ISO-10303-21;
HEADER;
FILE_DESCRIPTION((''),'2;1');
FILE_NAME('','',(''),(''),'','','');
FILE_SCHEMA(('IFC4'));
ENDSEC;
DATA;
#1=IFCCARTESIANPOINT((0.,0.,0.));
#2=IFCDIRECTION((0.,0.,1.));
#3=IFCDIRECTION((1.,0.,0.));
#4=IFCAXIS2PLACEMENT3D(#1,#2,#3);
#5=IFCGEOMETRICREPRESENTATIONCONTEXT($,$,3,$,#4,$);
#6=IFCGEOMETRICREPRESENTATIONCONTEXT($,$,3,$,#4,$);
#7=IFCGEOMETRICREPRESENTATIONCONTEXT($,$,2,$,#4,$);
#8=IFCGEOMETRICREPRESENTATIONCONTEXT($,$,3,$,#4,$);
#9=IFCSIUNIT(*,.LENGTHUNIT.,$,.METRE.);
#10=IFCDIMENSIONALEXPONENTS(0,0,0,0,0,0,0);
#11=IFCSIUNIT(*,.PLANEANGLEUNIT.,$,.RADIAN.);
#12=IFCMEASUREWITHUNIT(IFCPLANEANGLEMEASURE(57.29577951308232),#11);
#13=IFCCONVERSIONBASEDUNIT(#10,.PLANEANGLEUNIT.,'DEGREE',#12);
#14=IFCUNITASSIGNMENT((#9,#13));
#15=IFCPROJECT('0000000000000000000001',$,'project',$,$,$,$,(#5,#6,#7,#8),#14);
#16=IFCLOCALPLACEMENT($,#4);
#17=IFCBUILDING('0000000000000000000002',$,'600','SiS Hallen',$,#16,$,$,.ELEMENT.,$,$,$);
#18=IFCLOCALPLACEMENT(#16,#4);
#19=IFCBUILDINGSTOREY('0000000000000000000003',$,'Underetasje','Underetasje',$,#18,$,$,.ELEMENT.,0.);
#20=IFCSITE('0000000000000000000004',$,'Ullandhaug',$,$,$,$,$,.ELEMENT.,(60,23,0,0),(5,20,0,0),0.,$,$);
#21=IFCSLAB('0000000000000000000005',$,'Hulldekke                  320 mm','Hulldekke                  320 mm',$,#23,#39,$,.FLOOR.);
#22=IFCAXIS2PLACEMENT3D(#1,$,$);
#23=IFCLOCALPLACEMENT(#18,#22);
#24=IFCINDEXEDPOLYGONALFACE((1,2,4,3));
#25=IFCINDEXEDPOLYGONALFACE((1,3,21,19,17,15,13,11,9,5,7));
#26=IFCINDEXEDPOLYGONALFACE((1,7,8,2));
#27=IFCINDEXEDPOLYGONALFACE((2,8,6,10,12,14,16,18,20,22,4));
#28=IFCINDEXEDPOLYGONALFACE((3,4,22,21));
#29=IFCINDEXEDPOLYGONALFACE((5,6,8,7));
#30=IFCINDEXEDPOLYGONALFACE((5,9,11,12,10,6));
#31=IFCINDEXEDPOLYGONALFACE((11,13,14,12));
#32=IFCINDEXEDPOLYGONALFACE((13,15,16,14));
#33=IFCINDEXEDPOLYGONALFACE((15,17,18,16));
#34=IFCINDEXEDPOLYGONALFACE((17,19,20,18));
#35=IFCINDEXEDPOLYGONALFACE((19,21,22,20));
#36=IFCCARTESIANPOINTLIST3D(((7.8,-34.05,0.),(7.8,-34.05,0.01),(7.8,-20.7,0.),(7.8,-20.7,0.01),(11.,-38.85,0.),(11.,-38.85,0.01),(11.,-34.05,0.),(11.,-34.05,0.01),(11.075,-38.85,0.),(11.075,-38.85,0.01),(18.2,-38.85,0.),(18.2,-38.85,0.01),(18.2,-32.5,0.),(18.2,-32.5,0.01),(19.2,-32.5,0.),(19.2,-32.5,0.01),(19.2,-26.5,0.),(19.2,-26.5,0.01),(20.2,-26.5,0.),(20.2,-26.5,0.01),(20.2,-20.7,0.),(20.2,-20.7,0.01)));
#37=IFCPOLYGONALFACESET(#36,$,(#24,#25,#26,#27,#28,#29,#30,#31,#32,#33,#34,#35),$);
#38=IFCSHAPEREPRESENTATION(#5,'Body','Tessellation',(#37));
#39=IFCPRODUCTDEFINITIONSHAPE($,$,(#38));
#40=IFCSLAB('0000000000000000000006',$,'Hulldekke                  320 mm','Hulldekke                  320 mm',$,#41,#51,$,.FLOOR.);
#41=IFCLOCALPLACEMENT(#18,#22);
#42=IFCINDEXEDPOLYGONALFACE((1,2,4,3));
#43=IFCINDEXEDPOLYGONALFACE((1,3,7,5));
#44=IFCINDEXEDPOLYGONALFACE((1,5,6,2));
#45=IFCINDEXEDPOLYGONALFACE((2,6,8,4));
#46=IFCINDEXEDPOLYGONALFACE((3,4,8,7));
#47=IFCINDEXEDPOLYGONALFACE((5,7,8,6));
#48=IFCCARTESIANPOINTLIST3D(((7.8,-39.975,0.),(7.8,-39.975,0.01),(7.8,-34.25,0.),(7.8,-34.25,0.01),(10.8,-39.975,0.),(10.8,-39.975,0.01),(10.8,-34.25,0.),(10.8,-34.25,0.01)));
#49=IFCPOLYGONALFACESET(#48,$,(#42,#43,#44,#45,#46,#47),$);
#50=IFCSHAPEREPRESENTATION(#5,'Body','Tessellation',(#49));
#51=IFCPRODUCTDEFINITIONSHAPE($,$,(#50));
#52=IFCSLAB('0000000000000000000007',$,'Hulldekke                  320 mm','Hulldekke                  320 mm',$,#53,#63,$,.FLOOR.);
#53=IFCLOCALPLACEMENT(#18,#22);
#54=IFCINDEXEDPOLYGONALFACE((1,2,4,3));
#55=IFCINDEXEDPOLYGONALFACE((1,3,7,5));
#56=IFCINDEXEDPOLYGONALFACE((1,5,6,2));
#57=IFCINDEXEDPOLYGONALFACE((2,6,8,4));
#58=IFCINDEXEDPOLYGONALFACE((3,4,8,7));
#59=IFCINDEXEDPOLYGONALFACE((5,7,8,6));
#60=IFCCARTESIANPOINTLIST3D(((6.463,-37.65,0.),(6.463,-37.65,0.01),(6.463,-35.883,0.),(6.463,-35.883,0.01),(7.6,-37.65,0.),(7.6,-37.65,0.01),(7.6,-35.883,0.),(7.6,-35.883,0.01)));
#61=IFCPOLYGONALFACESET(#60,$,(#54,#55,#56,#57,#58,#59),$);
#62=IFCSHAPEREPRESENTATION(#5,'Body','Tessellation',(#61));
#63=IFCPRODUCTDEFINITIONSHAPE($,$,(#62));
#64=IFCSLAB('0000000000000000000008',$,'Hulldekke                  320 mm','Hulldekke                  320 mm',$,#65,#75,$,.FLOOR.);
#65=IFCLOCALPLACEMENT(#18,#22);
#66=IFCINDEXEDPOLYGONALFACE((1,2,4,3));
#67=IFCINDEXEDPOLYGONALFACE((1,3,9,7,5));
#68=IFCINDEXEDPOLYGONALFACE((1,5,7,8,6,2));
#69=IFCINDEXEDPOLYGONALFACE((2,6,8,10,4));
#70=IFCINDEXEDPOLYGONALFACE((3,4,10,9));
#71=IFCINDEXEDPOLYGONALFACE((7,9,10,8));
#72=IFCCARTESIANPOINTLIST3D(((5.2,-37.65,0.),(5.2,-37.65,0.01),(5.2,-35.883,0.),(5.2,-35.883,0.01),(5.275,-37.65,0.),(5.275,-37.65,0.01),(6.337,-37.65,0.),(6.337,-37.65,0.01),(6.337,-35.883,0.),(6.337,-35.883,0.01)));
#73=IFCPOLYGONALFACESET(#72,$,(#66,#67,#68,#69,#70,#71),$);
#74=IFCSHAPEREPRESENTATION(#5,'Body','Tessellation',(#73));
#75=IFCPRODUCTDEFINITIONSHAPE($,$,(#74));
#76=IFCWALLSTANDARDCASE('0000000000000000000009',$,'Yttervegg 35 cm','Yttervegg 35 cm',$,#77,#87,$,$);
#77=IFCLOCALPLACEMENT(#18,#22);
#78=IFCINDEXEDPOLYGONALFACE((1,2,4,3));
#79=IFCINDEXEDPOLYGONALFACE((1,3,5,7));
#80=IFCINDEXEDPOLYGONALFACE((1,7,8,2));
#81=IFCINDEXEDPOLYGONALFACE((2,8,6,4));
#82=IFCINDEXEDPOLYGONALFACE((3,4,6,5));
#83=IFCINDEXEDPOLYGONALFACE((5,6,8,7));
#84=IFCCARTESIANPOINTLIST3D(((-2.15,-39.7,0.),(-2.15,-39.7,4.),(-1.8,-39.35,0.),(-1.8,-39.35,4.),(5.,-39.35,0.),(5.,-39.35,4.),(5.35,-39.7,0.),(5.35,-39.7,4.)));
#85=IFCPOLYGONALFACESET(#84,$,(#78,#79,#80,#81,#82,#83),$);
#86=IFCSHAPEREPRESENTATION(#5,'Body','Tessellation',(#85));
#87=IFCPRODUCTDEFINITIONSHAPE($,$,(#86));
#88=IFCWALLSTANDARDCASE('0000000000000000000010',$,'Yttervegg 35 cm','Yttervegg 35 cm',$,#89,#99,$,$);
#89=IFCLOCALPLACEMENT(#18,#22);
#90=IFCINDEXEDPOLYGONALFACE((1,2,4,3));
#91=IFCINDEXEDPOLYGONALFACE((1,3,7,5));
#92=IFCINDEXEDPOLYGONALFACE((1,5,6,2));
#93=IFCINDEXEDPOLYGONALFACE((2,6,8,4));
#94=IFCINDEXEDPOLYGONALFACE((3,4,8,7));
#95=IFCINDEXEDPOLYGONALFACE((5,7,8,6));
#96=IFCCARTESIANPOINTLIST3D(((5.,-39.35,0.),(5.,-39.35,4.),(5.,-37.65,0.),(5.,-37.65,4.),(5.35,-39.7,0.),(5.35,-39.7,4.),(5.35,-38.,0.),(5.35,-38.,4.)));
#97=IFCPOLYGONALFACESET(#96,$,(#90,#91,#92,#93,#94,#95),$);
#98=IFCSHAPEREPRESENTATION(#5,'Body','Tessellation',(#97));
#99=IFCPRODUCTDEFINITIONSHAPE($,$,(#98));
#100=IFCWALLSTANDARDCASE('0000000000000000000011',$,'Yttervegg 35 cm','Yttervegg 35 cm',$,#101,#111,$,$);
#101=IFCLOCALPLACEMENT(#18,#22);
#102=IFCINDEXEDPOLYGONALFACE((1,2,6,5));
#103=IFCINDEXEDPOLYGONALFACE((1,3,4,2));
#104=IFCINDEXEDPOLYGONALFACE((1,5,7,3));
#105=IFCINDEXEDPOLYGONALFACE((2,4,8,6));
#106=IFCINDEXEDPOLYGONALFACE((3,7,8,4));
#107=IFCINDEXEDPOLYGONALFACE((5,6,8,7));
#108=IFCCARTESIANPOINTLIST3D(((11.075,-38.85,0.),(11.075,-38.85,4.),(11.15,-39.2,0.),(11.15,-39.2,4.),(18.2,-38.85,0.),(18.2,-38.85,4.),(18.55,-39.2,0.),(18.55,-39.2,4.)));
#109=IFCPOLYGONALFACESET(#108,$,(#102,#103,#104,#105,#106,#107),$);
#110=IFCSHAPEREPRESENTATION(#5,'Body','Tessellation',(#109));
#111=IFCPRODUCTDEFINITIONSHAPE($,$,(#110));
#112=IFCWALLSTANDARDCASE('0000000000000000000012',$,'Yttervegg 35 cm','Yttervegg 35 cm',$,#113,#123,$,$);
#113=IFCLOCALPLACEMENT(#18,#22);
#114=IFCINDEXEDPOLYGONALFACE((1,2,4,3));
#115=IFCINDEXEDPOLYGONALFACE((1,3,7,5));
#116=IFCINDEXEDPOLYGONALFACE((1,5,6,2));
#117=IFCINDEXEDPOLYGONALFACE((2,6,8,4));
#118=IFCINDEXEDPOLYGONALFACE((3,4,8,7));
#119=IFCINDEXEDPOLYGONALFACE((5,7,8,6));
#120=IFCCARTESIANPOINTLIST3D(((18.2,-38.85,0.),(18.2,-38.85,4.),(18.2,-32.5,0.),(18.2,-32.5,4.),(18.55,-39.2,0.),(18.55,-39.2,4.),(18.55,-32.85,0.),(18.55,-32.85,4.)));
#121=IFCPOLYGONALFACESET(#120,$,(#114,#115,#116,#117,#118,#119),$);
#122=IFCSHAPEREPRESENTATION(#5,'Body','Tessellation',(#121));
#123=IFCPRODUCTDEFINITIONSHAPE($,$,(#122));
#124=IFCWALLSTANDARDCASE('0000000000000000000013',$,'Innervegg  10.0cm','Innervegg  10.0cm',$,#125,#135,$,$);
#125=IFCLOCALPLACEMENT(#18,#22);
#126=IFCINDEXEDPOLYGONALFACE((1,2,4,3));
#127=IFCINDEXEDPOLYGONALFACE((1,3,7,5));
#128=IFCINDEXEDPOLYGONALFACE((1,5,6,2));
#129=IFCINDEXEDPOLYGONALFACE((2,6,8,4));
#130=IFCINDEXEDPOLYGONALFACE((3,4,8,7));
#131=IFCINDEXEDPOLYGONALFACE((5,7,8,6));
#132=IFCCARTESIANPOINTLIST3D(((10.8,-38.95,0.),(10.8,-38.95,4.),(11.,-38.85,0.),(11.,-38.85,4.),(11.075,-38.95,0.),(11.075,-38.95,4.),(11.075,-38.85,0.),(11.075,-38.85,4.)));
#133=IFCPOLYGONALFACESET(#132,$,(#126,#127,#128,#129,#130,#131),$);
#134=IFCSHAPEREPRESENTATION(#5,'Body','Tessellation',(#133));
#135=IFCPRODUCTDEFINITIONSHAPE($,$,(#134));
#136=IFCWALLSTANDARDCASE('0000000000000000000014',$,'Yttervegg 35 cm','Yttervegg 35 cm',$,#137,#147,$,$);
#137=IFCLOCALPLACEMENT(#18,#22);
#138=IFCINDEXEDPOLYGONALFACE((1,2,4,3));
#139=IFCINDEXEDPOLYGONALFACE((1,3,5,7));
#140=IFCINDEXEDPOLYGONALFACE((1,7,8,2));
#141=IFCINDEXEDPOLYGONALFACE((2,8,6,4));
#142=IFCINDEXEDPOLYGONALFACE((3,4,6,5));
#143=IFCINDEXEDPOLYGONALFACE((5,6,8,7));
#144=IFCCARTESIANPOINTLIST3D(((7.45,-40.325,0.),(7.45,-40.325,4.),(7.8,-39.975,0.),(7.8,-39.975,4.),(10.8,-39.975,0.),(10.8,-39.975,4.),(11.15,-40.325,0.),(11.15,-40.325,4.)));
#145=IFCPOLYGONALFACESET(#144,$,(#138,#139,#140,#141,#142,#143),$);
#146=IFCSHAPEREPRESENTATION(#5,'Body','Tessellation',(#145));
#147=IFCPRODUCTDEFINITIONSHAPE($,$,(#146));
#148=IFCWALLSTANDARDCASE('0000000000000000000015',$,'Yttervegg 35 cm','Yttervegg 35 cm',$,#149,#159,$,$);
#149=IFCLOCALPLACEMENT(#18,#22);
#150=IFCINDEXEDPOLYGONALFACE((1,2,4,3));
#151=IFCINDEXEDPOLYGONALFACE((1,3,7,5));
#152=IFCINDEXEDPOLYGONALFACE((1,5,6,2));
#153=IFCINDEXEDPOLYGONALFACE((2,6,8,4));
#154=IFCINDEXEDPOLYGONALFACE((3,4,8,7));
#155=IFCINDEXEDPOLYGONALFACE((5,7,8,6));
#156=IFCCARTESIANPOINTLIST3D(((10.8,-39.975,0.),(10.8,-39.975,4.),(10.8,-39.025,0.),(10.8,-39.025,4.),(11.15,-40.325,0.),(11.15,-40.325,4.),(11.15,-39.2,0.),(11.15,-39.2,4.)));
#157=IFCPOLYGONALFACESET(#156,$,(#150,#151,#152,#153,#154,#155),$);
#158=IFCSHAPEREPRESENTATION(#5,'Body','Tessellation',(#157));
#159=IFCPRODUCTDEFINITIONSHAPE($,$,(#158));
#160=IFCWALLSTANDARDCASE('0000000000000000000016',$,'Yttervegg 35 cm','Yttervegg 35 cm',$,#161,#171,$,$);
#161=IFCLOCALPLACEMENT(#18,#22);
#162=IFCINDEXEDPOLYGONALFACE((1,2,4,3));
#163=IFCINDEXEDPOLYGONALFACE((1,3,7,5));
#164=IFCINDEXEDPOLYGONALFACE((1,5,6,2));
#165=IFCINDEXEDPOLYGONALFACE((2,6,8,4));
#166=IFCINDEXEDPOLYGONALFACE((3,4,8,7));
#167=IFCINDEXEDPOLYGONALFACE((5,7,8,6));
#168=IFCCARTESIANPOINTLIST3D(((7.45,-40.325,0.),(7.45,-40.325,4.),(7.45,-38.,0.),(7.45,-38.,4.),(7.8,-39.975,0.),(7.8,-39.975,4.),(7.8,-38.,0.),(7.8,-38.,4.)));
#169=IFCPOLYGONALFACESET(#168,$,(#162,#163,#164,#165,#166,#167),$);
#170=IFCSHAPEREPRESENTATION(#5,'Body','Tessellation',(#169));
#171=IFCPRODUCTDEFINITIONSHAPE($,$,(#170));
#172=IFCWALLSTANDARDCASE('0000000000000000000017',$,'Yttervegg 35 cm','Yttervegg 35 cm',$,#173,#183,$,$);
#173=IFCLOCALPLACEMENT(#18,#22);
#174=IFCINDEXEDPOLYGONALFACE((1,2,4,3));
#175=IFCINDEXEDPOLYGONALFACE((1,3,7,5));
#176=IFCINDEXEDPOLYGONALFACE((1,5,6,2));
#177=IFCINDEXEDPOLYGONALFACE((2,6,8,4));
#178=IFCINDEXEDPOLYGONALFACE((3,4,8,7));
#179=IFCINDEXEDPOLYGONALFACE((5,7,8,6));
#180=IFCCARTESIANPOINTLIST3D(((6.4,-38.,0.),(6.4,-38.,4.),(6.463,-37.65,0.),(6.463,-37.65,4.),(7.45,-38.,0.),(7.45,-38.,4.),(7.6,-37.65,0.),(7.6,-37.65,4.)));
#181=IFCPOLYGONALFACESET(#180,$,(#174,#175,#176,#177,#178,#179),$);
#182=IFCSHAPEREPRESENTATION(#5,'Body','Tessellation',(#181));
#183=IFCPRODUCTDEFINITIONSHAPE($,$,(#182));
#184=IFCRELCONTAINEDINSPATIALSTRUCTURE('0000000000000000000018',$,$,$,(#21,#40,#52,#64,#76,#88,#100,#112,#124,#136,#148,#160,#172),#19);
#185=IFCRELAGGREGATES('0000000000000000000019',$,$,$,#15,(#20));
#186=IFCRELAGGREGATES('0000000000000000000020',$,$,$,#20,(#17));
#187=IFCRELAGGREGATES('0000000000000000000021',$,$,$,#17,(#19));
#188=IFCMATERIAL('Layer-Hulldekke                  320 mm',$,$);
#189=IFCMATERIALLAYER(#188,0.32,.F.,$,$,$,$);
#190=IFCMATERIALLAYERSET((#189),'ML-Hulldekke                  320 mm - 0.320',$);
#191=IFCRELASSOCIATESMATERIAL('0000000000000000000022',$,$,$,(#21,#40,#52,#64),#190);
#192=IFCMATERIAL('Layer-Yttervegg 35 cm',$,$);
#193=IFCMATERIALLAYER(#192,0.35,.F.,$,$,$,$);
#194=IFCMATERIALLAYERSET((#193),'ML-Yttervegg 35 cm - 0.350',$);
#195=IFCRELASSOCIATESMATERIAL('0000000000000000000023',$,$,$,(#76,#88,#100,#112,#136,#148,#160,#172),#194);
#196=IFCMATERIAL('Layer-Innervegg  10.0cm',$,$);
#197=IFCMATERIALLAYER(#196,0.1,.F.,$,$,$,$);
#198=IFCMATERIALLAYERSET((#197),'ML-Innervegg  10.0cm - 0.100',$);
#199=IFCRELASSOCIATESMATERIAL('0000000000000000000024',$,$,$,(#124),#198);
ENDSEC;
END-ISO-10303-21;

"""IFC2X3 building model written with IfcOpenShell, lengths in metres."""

from ifc_helpers import new_model, entity, si_unit, converted_unit, frame, origin_with_axes, place, context, project, spatial, polyline, outline, extrude, material, layer, layer_set, layer_usage, element, save


model = new_model("IFC2X3")

# Units and contexts
context_of_model_1 = context(None, 3, world=origin_with_axes())
context_of_model_2 = context(None, 3, world=origin_with_axes())
context_of_model_3 = context(None, 2, world=origin_with_axes())
context_of_model_4 = context(None, 3, world=origin_with_axes())
ifc_project = project(units=[si_unit("LENGTHUNIT", "METRE"), converted_unit("PLANEANGLEUNIT", "DEGREE", entity("IfcPlaneAngleMeasure", 57.29577951308232), si_unit("PLANEANGLEUNIT", "RADIAN"), dimensions=[0, 0, 0, 0, 0, 0, 0])], contexts=[context_of_model_1, context_of_model_2, context_of_model_3, context_of_model_4])

# Site, building, storey
site = spatial("IfcSite", under=ifc_project, Name="Ullandhaug", CompositionType="ELEMENT", RefLatitude=(60, 23, 0, 0), RefLongitude=(5, 20, 0, 0), RefElevation=0.0)
building_placement = place(None, origin_with_axes())
building = spatial("IfcBuilding", under=site, at=building_placement, Name="600", Description="SiS Hallen", CompositionType="ELEMENT")
storey_placement = place(building_placement, origin_with_axes())
storey = spatial("IfcBuildingStorey", under=building, at=storey_placement, Name="Underetasje", Description="Underetasje", CompositionType="ELEMENT", Elevation=0.0)

# Slabs
ifc_material_1 = material(Name="Layer-Hulldekke                  320 mm")
ifc_layer_1 = layer(ifc_material_1, 0.32, ventilated=False)
ifc_layer_set_1 = layer_set([ifc_layer_1], Name="ML-Hulldekke                  320 mm - 0.320")
ifc_layer_usage_1 = layer_usage(ifc_layer_set_1, "AXIS2", "POSITIVE", 0.0)
slab_1_placement = place(storey_placement, frame((11.075, -38.85, 0.0), z_axis=(0.0, 0.0, 1.0), x_axis=(1.0, 0.0, 0.0)))
element("IfcSlab", 1, at=slab_1_placement, inside=storey, material=ifc_layer_usage_1, Name="Hulldekke                  320 mm", Description="Hulldekke                  320 mm", PredefinedType="FLOOR", context=context_of_model_1, shape_type="SweptSolid", body=[
    extrude(outline(polyline([(0.0, 0.0), (7.125, 0.0), (7.125, 6.35), (8.125, 6.35), (8.125, 12.35), (9.125, 12.35), (9.125, 18.15), (-3.275, 18.15), (-3.275, 4.8), (-0.075, 4.8), (-0.075, 0.0), (0.0, 0.0)])), origin_with_axes(), (0.0, 0.0, 1.0), 0.01),
])
slab_2_placement = place(storey_placement, frame((7.8, -39.975, 0.0), z_axis=(0.0, 0.0, 1.0), x_axis=(1.0, 0.0, 0.0)))
element("IfcSlab", 2, at=slab_2_placement, inside=storey, material=ifc_layer_usage_1, Name="Hulldekke                  320 mm", Description="Hulldekke                  320 mm", PredefinedType="FLOOR", context=context_of_model_1, shape_type="SweptSolid", body=[
    extrude(outline(polyline([(0.0, 0.0), (3.0, 0.0), (3.0, 5.725), (0.0, 5.725), (0.0, 0.0)])), origin_with_axes(), (0.0, 0.0, 1.0), 0.01),
])
slab_3_placement = place(storey_placement, frame((6.463, -37.65, 0.0), z_axis=(0.0, 0.0, 1.0), x_axis=(1.0, 0.0, 0.0)))
element("IfcSlab", 3, at=slab_3_placement, inside=storey, material=ifc_layer_usage_1, Name="Hulldekke                  320 mm", Description="Hulldekke                  320 mm", PredefinedType="FLOOR", context=context_of_model_1, shape_type="SweptSolid", body=[
    extrude(outline(polyline([(0.0, 0.0), (1.137, 0.0), (1.137, 1.767), (0.0, 1.767), (0.0, 0.0)])), origin_with_axes(), (0.0, 0.0, 1.0), 0.01),
])
slab_4_placement = place(storey_placement, frame((5.275, -37.65, 0.0), z_axis=(0.0, 0.0, 1.0), x_axis=(1.0, 0.0, 0.0)))
element("IfcSlab", 4, at=slab_4_placement, inside=storey, material=ifc_layer_usage_1, Name="Hulldekke                  320 mm", Description="Hulldekke                  320 mm", PredefinedType="FLOOR", context=context_of_model_1, shape_type="SweptSolid", body=[
    extrude(outline(polyline([(0.0, 0.0), (1.062, 0.0), (1.062, 1.767), (-0.075, 1.767), (-0.075, 0.0), (0.0, 0.0)])), origin_with_axes(), (0.0, 0.0, 1.0), 0.01),
])

# Walls
ifc_material_2 = material(Name="Layer-Yttervegg 35 cm")
ifc_layer_2 = layer(ifc_material_2, 0.35, ventilated=False)
ifc_layer_set_2 = layer_set([ifc_layer_2], Name="ML-Yttervegg 35 cm - 0.350")
ifc_layer_usage_2 = layer_usage(ifc_layer_set_2, "AXIS2", "POSITIVE", 0.0)
wall_1_placement = place(storey_placement, frame((-2.15, -39.7, 0.0), z_axis=(0.0, 0.0, 1.0), x_axis=(1.0, 0.0, 0.0)))
element("IfcWallStandardCase", 5, at=wall_1_placement, inside=storey, material=ifc_layer_usage_2, Name="Yttervegg 35 cm", Description="Yttervegg 35 cm", context=context_of_model_1, shape_type="SweptSolid", body=[
    extrude(outline(polyline([(0.0, 0.0), (7.5, 0.0), (7.15, 0.35), (0.35, 0.35), (0.0, 0.0)])), origin_with_axes(), (0.0, 0.0, 1.0), 4.0),
])
wall_2_placement = place(storey_placement, frame((5.35, -39.7, 0.0), z_axis=(0.0, 0.0, 1.0), x_axis=(0.0, 1.0, 0.0)))
element("IfcWallStandardCase", 6, at=wall_2_placement, inside=storey, material=ifc_layer_usage_2, Name="Yttervegg 35 cm", Description="Yttervegg 35 cm", context=context_of_model_1, shape_type="SweptSolid", body=[
    extrude(outline(polyline([(0.0, 0.0), (1.7, 0.0), (2.05, 0.35), (0.35, 0.35), (0.0, 0.0)])), frame((0.0, 0.0, 0.0), z_axis=(0.0, 0.0, 1.0), x_axis=(1.0, 0.0, 0.0)), (0.0, 0.0, 1.0), 4.0),
])
wall_3_placement = place(storey_placement, frame((11.15, -39.2, 0.0), z_axis=(0.0, 0.0, 1.0), x_axis=(1.0, 0.0, 0.0)))
element("IfcWallStandardCase", 7, at=wall_3_placement, inside=storey, material=ifc_layer_usage_2, Name="Yttervegg 35 cm", Description="Yttervegg 35 cm", context=context_of_model_1, shape_type="SweptSolid", body=[
    extrude(outline(polyline([(0.0, 0.0), (7.4, 0.0), (7.05, 0.35), (-0.075, 0.35), (0.0, 0.0)])), origin_with_axes(), (0.0, 0.0, 1.0), 4.0),
])
wall_4_placement = place(storey_placement, frame((18.55, -39.2, 0.0), z_axis=(0.0, 0.0, 1.0), x_axis=(0.0, 1.0, 0.0)))
element("IfcWallStandardCase", 8, at=wall_4_placement, inside=storey, material=ifc_layer_usage_2, Name="Yttervegg 35 cm", Description="Yttervegg 35 cm", context=context_of_model_1, shape_type="SweptSolid", body=[
    extrude(outline(polyline([(0.0, 0.0), (6.35, 0.0), (6.7, 0.35), (0.35, 0.35), (0.0, 0.0)])), frame((0.0, 0.0, 0.0), z_axis=(0.0, 0.0, 1.0), x_axis=(1.0, 0.0, 0.0)), (0.0, 0.0, 1.0), 4.0),
])
ifc_material_3 = material(Name="Layer-Innervegg  10.0cm")
ifc_layer_3 = layer(ifc_material_3, 0.1, ventilated=False)
ifc_layer_set_3 = layer_set([ifc_layer_3], Name="ML-Innervegg  10.0cm - 0.100")
ifc_layer_usage_3 = layer_usage(ifc_layer_set_3, "AXIS2", "POSITIVE", 0.0)
wall_5_placement = place(storey_placement, frame((10.8, -38.95, 0.0), z_axis=(0.0, 0.0, 1.0), x_axis=(1.0, 0.0, 0.0)))
element("IfcWallStandardCase", 9, at=wall_5_placement, inside=storey, material=ifc_layer_usage_3, Name="Innervegg  10.0cm", Description="Innervegg  10.0cm", context=context_of_model_1, shape_type="SweptSolid", body=[
    extrude(outline(polyline([(0.0, 0.0), (0.275, 0.0), (0.275, 0.1), (0.2, 0.1), (0.0, 0.0)])), origin_with_axes(), (0.0, 0.0, 1.0), 4.0),
])
wall_6_placement = place(storey_placement, frame((7.45, -40.325, 0.0), z_axis=(0.0, 0.0, 1.0), x_axis=(1.0, 0.0, 0.0)))
element("IfcWallStandardCase", 10, at=wall_6_placement, inside=storey, material=ifc_layer_usage_2, Name="Yttervegg 35 cm", Description="Yttervegg 35 cm", context=context_of_model_1, shape_type="SweptSolid", body=[
    extrude(outline(polyline([(0.0, 0.0), (3.7, 0.0), (3.35, 0.35), (0.35, 0.35), (0.0, 0.0)])), origin_with_axes(), (0.0, 0.0, 1.0), 4.0),
])
wall_7_placement = place(storey_placement, frame((11.15, -40.325, 0.0), z_axis=(0.0, 0.0, 1.0), x_axis=(0.0, 1.0, 0.0)))
element("IfcWallStandardCase", 11, at=wall_7_placement, inside=storey, material=ifc_layer_usage_2, Name="Yttervegg 35 cm", Description="Yttervegg 35 cm", context=context_of_model_1, shape_type="SweptSolid", body=[
    extrude(outline(polyline([(0.0, 0.0), (1.125, 0.0), (1.3, 0.35), (0.35, 0.35), (0.0, 0.0)])), frame((0.0, 0.0, 0.0), z_axis=(0.0, 0.0, 1.0), x_axis=(1.0, 0.0, 0.0)), (0.0, 0.0, 1.0), 4.0),
])
wall_8_placement = place(storey_placement, frame((7.45, -38.0, 0.0), z_axis=(0.0, 0.0, 1.0), x_axis=(0.0, -1.0, 0.0)))
element("IfcWallStandardCase", 12, at=wall_8_placement, inside=storey, material=ifc_layer_usage_2, Name="Yttervegg 35 cm", Description="Yttervegg 35 cm", context=context_of_model_1, shape_type="SweptSolid", body=[
    extrude(outline(polyline([(0.0, 0.0), (2.325, 0.0), (1.975, 0.35), (0.0, 0.35), (0.0, 0.0)])), frame((0.0, 0.0, 0.0), z_axis=(0.0, 0.0, 1.0), x_axis=(1.0, 0.0, 0.0)), (0.0, 0.0, 1.0), 4.0),
])
wall_9_placement = place(storey_placement, frame((6.4, -38.0, 0.0), z_axis=(0.0, 0.0, 1.0), x_axis=(1.0, 0.0, 0.0)))
element("IfcWallStandardCase", 13, at=wall_9_placement, inside=storey, material=ifc_layer_usage_2, Name="Yttervegg 35 cm", Description="Yttervegg 35 cm", context=context_of_model_1, shape_type="SweptSolid", body=[
    extrude(outline(polyline([(0.0, 0.0), (1.05, 0.0), (1.2, 0.35), (0.063, 0.35), (0.0, 0.0)])), origin_with_axes(), (0.0, 0.0, 1.0), 4.0),
])

save(model, "model.ifc")
